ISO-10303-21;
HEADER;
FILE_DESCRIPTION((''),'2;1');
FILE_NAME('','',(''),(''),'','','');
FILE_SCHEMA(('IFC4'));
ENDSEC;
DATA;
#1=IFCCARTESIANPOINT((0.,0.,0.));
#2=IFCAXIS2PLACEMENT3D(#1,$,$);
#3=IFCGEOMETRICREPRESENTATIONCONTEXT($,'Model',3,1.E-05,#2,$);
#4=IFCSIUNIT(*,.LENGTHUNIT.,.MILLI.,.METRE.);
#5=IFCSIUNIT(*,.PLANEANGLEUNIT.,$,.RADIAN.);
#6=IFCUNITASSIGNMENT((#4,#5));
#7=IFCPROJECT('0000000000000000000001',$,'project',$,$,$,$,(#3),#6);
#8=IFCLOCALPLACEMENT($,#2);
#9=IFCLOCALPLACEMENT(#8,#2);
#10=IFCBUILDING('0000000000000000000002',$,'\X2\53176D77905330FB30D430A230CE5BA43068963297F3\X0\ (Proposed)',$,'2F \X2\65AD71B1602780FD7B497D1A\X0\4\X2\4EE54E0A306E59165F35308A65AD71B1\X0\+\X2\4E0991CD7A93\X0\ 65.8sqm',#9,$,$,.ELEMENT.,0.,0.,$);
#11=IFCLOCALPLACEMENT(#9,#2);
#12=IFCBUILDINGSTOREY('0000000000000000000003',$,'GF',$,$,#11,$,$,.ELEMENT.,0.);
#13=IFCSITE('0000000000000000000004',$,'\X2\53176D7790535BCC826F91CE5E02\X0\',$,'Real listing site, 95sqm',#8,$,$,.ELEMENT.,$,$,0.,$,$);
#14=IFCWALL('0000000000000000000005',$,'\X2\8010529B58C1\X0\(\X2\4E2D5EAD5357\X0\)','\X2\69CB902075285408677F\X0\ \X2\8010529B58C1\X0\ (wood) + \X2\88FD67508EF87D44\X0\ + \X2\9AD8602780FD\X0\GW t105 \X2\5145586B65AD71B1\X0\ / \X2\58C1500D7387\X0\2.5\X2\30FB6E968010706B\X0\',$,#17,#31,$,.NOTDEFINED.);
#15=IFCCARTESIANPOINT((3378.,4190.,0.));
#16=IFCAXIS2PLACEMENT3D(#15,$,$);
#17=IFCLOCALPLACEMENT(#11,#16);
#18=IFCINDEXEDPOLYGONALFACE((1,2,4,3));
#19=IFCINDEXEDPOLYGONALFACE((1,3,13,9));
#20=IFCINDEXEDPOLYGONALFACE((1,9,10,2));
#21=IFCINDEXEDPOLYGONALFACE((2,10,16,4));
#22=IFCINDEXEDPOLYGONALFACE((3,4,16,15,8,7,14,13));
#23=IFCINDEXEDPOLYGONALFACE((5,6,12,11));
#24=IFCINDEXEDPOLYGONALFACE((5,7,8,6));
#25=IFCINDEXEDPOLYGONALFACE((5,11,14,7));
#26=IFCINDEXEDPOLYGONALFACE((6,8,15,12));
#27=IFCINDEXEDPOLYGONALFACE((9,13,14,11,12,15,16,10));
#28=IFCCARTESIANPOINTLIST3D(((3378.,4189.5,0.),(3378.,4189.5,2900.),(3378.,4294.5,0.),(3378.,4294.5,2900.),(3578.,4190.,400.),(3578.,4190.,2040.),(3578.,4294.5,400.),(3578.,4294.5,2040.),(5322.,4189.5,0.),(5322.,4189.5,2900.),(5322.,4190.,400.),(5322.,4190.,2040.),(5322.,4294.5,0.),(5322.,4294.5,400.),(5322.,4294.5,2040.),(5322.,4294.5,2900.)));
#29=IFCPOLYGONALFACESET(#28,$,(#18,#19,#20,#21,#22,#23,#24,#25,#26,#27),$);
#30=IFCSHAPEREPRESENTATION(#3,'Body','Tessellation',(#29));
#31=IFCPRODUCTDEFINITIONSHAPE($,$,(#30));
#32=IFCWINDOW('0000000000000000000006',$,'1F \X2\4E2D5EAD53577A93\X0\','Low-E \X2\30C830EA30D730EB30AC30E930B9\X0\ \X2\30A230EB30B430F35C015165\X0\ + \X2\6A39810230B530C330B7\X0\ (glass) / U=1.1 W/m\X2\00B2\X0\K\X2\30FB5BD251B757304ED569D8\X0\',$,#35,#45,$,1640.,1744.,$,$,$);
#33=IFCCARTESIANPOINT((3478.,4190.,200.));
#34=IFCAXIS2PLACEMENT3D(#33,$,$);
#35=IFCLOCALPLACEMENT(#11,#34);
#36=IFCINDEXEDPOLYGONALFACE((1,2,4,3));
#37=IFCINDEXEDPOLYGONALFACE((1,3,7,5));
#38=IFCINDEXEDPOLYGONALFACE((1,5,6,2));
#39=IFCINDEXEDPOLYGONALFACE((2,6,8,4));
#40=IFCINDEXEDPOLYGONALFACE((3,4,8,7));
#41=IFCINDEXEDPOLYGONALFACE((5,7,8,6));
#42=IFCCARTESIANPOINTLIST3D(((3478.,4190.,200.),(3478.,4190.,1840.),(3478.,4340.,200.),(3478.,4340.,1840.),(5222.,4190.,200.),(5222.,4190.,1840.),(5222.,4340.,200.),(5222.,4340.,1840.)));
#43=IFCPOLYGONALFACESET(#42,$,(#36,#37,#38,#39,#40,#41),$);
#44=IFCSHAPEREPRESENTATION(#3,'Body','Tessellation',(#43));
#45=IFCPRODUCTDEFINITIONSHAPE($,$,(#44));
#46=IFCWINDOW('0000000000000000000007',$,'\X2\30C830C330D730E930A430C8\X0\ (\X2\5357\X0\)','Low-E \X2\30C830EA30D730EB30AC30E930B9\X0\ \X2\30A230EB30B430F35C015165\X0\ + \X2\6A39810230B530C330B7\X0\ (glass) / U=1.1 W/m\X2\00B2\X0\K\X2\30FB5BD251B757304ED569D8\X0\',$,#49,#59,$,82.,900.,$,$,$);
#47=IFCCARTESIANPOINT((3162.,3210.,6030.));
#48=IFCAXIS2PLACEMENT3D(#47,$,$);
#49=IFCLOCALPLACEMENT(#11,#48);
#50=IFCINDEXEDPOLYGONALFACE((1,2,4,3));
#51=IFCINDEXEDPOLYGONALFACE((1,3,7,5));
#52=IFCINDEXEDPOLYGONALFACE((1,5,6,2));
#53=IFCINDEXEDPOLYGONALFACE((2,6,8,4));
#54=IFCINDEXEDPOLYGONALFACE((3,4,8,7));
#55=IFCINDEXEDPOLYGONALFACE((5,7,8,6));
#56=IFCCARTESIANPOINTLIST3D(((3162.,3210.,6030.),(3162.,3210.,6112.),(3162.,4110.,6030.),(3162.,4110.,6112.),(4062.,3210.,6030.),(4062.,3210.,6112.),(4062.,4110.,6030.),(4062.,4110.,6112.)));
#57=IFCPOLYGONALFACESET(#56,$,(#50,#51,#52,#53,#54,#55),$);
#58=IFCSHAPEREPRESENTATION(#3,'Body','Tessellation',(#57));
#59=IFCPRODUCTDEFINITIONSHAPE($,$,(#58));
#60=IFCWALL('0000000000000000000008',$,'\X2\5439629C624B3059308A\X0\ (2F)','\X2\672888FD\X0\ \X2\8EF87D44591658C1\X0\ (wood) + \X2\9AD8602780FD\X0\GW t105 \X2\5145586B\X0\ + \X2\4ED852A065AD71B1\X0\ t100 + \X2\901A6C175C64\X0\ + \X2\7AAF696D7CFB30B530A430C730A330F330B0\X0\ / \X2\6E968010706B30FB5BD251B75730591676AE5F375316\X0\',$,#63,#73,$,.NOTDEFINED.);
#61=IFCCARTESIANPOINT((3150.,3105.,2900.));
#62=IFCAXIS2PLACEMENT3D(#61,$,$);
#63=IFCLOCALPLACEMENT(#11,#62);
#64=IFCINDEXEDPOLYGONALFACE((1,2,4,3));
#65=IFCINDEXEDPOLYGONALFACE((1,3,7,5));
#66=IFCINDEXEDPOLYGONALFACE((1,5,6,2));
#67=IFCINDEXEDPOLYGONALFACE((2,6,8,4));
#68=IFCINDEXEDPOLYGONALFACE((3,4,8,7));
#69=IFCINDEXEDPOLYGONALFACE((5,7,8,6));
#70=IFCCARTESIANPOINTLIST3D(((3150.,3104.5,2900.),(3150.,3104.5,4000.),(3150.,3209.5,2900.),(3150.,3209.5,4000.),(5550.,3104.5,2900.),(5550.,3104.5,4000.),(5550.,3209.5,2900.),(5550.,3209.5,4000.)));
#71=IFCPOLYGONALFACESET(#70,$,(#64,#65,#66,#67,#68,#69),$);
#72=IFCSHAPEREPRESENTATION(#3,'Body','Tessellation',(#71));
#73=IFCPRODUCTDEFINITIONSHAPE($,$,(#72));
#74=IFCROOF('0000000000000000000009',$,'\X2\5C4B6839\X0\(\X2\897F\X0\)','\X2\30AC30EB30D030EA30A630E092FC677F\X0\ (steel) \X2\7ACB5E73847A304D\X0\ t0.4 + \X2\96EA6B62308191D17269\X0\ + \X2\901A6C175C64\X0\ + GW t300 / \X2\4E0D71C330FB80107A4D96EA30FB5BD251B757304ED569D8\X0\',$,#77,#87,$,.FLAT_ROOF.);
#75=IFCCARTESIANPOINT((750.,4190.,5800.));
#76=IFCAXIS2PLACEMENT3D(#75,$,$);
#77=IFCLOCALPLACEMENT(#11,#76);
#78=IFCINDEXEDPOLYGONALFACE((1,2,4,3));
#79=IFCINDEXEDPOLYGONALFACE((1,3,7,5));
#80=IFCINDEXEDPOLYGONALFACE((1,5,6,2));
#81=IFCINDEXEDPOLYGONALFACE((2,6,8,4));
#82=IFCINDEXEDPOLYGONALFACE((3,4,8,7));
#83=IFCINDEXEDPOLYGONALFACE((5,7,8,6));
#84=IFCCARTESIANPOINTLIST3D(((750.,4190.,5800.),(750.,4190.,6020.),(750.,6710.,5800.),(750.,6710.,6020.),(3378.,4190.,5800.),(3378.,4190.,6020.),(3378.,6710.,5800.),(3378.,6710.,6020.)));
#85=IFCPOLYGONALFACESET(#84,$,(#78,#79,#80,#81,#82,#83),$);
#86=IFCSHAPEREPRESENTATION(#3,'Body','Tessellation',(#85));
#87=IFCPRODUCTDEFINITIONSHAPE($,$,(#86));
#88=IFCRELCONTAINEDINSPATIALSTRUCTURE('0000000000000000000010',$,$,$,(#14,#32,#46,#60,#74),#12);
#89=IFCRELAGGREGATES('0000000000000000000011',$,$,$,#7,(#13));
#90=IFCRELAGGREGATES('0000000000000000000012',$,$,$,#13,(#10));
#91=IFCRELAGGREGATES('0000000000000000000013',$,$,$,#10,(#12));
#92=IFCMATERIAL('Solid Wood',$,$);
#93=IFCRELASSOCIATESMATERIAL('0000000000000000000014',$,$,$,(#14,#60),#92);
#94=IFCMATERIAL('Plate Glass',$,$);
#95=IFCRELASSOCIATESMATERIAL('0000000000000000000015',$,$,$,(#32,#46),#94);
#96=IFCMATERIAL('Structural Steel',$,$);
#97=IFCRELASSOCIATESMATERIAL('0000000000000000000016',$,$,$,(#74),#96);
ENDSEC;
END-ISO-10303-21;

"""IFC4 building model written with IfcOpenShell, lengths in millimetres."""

from ifc_helpers import new_model, si_unit, frame, frame_2d, origin, place, context, project, spatial, rectangle, extrude, material, element, fill, save


model = new_model("IFC4")

# Units and contexts
model_context = context("Model", 3, precision=1e-05, world=origin())
ifc_project = project(units=[si_unit("LENGTHUNIT", "METRE", prefix="MILLI"), si_unit("PLANEANGLEUNIT", "RADIAN")], contexts=[model_context])

# Site, building, storey
site_placement = place(None, origin())
site = spatial("IfcSite", under=ifc_project, at=site_placement, Name="北海道富良野市", ObjectType="Real listing site, 95sqm", CompositionType="ELEMENT", RefElevation=0.0)
building_placement = place(site_placement, origin())
building = spatial("IfcBuilding", under=site, at=building_placement, Name="北海道・ピアノ室と防音 (Proposed)", ObjectType="2F 断熱性能等級4以上の外張り断熱+三重窓 65.8sqm", CompositionType="ELEMENT", ElevationOfRefHeight=0.0, ElevationOfTerrain=0.0)
storey_placement = place(building_placement, origin())
storey = spatial("IfcBuildingStorey", under=building, at=storey_placement, Name="GF", CompositionType="ELEMENT", Elevation=0.0)

# Shared definitions
ifc_material_1 = material(Name="Solid Wood")

# Wall, opening, window
wall_1_placement = place(storey_placement, frame((3378.0, 4190.0, 0.0)))
wall_1 = element("IfcWall", 1, at=wall_1_placement, inside=storey, material=ifc_material_1, Name="耐力壁(中庭南)", Description="構造用合板 耐力壁 (wood) + 製材軸組 + 高性能GW t105 充填断熱 / 壁倍率2.5・準耐火", PredefinedType="NOTDEFINED", context=model_context, shape_type="SweptSolid", body=[
    extrude(rectangle(XDim=1944.0, YDim=105.0, at=frame_2d((972.0, 52.0))), frame((3378.0, 4190.0, 0.0)), (0.0, 0.0, 1.0), 2900.0),
])
opening_placement = place(storey_placement, frame((3478.0, 4190.0, 200.0)))
opening = element("IfcOpeningElement", 2, at=opening_placement, cuts=wall_1, PredefinedType="NOTDEFINED", context=model_context, shape_type="SweptSolid", body=[
    extrude(rectangle(XDim=1744.0, YDim=150.0, at=frame_2d((872.0, 75.0))), frame((3478.0, 4190.0, 200.0)), (0.0, 0.0, 1.0), 1640.0),
])
ifc_material_2 = material(Name="Plate Glass")
window_1_placement = place(storey_placement, frame((3478.0, 4190.0, 200.0)))
window_1 = element("IfcWindow", 3, at=window_1_placement, inside=storey, material=ifc_material_2, Name="1F 中庭南窓", Description="Low-E トリプルガラス アルゴン封入 + 樹脂サッシ (glass) / U=1.1 W/m²K・寒冷地仕様", OverallHeight=1640.0, OverallWidth=1744.0, context=model_context, shape_type="SweptSolid", body=[
    extrude(rectangle(XDim=1744.0, YDim=150.0, at=frame_2d((872.0, 75.0))), frame((3478.0, 4190.0, 200.0)), (0.0, 0.0, 1.0), 1640.0),
])
fill(opening, window_1)

# Window
window_2_placement = place(storey_placement, frame((3162.0, 3210.0, 6030.0)))
element("IfcWindow", 4, at=window_2_placement, inside=storey, material=ifc_material_2, Name="トップライト (南)", Description="Low-E トリプルガラス アルゴン封入 + 樹脂サッシ (glass) / U=1.1 W/m²K・寒冷地仕様", OverallHeight=82.0, OverallWidth=900.0, context=model_context, shape_type="SweptSolid", body=[
    extrude(rectangle(XDim=900.0, YDim=900.0, at=frame_2d((450.0, 450.0))), frame((3162.0, 3210.0, 6030.0)), (0.0, 0.0, 1.0), 82.0),
])

# Wall
wall_2_placement = place(storey_placement, frame((3150.0, 3105.0, 2900.0)))
element("IfcWall", 5, at=wall_2_placement, inside=storey, material=ifc_material_1, Name="吹抜手すり (2F)", Description="木製 軸組外壁 (wood) + 高性能GW t105 充填 + 付加断熱 t100 + 通気層 + 窯業系サイディング / 準耐火・寒冷地外皮強化", PredefinedType="NOTDEFINED", context=model_context, shape_type="SweptSolid", body=[
    extrude(rectangle(XDim=2400.0, YDim=105.0, at=frame_2d((1200.0, 52.0))), frame((3150.0, 3105.0, 2900.0)), (0.0, 0.0, 1.0), 1100.0),
])

# Roof
ifc_material_3 = material(Name="Structural Steel")
for number, where, name in (
    (6, (750.0, 4190.0, 5800.0), "屋根(西)"),
):
    element("IfcRoof", number, at=place(storey_placement, frame(where)), inside=storey, material=ifc_material_3, Name=name, Description="ガルバリウム鋼板 (steel) 立平葺き t0.4 + 雪止め金物 + 通気層 + GW t300 / 不燃・耐積雪・寒冷地仕様", PredefinedType="FLAT_ROOF", context=model_context, shape_type="SweptSolid", body=[
        extrude(rectangle(XDim=2628.0, YDim=2520.0, at=frame_2d((1314.0, 1260.0))), frame((750.0, 4190.0, 5800.0)), (0.0, 0.0, 1.0), 220.0),
    ])

save(model, "model.ifc")
